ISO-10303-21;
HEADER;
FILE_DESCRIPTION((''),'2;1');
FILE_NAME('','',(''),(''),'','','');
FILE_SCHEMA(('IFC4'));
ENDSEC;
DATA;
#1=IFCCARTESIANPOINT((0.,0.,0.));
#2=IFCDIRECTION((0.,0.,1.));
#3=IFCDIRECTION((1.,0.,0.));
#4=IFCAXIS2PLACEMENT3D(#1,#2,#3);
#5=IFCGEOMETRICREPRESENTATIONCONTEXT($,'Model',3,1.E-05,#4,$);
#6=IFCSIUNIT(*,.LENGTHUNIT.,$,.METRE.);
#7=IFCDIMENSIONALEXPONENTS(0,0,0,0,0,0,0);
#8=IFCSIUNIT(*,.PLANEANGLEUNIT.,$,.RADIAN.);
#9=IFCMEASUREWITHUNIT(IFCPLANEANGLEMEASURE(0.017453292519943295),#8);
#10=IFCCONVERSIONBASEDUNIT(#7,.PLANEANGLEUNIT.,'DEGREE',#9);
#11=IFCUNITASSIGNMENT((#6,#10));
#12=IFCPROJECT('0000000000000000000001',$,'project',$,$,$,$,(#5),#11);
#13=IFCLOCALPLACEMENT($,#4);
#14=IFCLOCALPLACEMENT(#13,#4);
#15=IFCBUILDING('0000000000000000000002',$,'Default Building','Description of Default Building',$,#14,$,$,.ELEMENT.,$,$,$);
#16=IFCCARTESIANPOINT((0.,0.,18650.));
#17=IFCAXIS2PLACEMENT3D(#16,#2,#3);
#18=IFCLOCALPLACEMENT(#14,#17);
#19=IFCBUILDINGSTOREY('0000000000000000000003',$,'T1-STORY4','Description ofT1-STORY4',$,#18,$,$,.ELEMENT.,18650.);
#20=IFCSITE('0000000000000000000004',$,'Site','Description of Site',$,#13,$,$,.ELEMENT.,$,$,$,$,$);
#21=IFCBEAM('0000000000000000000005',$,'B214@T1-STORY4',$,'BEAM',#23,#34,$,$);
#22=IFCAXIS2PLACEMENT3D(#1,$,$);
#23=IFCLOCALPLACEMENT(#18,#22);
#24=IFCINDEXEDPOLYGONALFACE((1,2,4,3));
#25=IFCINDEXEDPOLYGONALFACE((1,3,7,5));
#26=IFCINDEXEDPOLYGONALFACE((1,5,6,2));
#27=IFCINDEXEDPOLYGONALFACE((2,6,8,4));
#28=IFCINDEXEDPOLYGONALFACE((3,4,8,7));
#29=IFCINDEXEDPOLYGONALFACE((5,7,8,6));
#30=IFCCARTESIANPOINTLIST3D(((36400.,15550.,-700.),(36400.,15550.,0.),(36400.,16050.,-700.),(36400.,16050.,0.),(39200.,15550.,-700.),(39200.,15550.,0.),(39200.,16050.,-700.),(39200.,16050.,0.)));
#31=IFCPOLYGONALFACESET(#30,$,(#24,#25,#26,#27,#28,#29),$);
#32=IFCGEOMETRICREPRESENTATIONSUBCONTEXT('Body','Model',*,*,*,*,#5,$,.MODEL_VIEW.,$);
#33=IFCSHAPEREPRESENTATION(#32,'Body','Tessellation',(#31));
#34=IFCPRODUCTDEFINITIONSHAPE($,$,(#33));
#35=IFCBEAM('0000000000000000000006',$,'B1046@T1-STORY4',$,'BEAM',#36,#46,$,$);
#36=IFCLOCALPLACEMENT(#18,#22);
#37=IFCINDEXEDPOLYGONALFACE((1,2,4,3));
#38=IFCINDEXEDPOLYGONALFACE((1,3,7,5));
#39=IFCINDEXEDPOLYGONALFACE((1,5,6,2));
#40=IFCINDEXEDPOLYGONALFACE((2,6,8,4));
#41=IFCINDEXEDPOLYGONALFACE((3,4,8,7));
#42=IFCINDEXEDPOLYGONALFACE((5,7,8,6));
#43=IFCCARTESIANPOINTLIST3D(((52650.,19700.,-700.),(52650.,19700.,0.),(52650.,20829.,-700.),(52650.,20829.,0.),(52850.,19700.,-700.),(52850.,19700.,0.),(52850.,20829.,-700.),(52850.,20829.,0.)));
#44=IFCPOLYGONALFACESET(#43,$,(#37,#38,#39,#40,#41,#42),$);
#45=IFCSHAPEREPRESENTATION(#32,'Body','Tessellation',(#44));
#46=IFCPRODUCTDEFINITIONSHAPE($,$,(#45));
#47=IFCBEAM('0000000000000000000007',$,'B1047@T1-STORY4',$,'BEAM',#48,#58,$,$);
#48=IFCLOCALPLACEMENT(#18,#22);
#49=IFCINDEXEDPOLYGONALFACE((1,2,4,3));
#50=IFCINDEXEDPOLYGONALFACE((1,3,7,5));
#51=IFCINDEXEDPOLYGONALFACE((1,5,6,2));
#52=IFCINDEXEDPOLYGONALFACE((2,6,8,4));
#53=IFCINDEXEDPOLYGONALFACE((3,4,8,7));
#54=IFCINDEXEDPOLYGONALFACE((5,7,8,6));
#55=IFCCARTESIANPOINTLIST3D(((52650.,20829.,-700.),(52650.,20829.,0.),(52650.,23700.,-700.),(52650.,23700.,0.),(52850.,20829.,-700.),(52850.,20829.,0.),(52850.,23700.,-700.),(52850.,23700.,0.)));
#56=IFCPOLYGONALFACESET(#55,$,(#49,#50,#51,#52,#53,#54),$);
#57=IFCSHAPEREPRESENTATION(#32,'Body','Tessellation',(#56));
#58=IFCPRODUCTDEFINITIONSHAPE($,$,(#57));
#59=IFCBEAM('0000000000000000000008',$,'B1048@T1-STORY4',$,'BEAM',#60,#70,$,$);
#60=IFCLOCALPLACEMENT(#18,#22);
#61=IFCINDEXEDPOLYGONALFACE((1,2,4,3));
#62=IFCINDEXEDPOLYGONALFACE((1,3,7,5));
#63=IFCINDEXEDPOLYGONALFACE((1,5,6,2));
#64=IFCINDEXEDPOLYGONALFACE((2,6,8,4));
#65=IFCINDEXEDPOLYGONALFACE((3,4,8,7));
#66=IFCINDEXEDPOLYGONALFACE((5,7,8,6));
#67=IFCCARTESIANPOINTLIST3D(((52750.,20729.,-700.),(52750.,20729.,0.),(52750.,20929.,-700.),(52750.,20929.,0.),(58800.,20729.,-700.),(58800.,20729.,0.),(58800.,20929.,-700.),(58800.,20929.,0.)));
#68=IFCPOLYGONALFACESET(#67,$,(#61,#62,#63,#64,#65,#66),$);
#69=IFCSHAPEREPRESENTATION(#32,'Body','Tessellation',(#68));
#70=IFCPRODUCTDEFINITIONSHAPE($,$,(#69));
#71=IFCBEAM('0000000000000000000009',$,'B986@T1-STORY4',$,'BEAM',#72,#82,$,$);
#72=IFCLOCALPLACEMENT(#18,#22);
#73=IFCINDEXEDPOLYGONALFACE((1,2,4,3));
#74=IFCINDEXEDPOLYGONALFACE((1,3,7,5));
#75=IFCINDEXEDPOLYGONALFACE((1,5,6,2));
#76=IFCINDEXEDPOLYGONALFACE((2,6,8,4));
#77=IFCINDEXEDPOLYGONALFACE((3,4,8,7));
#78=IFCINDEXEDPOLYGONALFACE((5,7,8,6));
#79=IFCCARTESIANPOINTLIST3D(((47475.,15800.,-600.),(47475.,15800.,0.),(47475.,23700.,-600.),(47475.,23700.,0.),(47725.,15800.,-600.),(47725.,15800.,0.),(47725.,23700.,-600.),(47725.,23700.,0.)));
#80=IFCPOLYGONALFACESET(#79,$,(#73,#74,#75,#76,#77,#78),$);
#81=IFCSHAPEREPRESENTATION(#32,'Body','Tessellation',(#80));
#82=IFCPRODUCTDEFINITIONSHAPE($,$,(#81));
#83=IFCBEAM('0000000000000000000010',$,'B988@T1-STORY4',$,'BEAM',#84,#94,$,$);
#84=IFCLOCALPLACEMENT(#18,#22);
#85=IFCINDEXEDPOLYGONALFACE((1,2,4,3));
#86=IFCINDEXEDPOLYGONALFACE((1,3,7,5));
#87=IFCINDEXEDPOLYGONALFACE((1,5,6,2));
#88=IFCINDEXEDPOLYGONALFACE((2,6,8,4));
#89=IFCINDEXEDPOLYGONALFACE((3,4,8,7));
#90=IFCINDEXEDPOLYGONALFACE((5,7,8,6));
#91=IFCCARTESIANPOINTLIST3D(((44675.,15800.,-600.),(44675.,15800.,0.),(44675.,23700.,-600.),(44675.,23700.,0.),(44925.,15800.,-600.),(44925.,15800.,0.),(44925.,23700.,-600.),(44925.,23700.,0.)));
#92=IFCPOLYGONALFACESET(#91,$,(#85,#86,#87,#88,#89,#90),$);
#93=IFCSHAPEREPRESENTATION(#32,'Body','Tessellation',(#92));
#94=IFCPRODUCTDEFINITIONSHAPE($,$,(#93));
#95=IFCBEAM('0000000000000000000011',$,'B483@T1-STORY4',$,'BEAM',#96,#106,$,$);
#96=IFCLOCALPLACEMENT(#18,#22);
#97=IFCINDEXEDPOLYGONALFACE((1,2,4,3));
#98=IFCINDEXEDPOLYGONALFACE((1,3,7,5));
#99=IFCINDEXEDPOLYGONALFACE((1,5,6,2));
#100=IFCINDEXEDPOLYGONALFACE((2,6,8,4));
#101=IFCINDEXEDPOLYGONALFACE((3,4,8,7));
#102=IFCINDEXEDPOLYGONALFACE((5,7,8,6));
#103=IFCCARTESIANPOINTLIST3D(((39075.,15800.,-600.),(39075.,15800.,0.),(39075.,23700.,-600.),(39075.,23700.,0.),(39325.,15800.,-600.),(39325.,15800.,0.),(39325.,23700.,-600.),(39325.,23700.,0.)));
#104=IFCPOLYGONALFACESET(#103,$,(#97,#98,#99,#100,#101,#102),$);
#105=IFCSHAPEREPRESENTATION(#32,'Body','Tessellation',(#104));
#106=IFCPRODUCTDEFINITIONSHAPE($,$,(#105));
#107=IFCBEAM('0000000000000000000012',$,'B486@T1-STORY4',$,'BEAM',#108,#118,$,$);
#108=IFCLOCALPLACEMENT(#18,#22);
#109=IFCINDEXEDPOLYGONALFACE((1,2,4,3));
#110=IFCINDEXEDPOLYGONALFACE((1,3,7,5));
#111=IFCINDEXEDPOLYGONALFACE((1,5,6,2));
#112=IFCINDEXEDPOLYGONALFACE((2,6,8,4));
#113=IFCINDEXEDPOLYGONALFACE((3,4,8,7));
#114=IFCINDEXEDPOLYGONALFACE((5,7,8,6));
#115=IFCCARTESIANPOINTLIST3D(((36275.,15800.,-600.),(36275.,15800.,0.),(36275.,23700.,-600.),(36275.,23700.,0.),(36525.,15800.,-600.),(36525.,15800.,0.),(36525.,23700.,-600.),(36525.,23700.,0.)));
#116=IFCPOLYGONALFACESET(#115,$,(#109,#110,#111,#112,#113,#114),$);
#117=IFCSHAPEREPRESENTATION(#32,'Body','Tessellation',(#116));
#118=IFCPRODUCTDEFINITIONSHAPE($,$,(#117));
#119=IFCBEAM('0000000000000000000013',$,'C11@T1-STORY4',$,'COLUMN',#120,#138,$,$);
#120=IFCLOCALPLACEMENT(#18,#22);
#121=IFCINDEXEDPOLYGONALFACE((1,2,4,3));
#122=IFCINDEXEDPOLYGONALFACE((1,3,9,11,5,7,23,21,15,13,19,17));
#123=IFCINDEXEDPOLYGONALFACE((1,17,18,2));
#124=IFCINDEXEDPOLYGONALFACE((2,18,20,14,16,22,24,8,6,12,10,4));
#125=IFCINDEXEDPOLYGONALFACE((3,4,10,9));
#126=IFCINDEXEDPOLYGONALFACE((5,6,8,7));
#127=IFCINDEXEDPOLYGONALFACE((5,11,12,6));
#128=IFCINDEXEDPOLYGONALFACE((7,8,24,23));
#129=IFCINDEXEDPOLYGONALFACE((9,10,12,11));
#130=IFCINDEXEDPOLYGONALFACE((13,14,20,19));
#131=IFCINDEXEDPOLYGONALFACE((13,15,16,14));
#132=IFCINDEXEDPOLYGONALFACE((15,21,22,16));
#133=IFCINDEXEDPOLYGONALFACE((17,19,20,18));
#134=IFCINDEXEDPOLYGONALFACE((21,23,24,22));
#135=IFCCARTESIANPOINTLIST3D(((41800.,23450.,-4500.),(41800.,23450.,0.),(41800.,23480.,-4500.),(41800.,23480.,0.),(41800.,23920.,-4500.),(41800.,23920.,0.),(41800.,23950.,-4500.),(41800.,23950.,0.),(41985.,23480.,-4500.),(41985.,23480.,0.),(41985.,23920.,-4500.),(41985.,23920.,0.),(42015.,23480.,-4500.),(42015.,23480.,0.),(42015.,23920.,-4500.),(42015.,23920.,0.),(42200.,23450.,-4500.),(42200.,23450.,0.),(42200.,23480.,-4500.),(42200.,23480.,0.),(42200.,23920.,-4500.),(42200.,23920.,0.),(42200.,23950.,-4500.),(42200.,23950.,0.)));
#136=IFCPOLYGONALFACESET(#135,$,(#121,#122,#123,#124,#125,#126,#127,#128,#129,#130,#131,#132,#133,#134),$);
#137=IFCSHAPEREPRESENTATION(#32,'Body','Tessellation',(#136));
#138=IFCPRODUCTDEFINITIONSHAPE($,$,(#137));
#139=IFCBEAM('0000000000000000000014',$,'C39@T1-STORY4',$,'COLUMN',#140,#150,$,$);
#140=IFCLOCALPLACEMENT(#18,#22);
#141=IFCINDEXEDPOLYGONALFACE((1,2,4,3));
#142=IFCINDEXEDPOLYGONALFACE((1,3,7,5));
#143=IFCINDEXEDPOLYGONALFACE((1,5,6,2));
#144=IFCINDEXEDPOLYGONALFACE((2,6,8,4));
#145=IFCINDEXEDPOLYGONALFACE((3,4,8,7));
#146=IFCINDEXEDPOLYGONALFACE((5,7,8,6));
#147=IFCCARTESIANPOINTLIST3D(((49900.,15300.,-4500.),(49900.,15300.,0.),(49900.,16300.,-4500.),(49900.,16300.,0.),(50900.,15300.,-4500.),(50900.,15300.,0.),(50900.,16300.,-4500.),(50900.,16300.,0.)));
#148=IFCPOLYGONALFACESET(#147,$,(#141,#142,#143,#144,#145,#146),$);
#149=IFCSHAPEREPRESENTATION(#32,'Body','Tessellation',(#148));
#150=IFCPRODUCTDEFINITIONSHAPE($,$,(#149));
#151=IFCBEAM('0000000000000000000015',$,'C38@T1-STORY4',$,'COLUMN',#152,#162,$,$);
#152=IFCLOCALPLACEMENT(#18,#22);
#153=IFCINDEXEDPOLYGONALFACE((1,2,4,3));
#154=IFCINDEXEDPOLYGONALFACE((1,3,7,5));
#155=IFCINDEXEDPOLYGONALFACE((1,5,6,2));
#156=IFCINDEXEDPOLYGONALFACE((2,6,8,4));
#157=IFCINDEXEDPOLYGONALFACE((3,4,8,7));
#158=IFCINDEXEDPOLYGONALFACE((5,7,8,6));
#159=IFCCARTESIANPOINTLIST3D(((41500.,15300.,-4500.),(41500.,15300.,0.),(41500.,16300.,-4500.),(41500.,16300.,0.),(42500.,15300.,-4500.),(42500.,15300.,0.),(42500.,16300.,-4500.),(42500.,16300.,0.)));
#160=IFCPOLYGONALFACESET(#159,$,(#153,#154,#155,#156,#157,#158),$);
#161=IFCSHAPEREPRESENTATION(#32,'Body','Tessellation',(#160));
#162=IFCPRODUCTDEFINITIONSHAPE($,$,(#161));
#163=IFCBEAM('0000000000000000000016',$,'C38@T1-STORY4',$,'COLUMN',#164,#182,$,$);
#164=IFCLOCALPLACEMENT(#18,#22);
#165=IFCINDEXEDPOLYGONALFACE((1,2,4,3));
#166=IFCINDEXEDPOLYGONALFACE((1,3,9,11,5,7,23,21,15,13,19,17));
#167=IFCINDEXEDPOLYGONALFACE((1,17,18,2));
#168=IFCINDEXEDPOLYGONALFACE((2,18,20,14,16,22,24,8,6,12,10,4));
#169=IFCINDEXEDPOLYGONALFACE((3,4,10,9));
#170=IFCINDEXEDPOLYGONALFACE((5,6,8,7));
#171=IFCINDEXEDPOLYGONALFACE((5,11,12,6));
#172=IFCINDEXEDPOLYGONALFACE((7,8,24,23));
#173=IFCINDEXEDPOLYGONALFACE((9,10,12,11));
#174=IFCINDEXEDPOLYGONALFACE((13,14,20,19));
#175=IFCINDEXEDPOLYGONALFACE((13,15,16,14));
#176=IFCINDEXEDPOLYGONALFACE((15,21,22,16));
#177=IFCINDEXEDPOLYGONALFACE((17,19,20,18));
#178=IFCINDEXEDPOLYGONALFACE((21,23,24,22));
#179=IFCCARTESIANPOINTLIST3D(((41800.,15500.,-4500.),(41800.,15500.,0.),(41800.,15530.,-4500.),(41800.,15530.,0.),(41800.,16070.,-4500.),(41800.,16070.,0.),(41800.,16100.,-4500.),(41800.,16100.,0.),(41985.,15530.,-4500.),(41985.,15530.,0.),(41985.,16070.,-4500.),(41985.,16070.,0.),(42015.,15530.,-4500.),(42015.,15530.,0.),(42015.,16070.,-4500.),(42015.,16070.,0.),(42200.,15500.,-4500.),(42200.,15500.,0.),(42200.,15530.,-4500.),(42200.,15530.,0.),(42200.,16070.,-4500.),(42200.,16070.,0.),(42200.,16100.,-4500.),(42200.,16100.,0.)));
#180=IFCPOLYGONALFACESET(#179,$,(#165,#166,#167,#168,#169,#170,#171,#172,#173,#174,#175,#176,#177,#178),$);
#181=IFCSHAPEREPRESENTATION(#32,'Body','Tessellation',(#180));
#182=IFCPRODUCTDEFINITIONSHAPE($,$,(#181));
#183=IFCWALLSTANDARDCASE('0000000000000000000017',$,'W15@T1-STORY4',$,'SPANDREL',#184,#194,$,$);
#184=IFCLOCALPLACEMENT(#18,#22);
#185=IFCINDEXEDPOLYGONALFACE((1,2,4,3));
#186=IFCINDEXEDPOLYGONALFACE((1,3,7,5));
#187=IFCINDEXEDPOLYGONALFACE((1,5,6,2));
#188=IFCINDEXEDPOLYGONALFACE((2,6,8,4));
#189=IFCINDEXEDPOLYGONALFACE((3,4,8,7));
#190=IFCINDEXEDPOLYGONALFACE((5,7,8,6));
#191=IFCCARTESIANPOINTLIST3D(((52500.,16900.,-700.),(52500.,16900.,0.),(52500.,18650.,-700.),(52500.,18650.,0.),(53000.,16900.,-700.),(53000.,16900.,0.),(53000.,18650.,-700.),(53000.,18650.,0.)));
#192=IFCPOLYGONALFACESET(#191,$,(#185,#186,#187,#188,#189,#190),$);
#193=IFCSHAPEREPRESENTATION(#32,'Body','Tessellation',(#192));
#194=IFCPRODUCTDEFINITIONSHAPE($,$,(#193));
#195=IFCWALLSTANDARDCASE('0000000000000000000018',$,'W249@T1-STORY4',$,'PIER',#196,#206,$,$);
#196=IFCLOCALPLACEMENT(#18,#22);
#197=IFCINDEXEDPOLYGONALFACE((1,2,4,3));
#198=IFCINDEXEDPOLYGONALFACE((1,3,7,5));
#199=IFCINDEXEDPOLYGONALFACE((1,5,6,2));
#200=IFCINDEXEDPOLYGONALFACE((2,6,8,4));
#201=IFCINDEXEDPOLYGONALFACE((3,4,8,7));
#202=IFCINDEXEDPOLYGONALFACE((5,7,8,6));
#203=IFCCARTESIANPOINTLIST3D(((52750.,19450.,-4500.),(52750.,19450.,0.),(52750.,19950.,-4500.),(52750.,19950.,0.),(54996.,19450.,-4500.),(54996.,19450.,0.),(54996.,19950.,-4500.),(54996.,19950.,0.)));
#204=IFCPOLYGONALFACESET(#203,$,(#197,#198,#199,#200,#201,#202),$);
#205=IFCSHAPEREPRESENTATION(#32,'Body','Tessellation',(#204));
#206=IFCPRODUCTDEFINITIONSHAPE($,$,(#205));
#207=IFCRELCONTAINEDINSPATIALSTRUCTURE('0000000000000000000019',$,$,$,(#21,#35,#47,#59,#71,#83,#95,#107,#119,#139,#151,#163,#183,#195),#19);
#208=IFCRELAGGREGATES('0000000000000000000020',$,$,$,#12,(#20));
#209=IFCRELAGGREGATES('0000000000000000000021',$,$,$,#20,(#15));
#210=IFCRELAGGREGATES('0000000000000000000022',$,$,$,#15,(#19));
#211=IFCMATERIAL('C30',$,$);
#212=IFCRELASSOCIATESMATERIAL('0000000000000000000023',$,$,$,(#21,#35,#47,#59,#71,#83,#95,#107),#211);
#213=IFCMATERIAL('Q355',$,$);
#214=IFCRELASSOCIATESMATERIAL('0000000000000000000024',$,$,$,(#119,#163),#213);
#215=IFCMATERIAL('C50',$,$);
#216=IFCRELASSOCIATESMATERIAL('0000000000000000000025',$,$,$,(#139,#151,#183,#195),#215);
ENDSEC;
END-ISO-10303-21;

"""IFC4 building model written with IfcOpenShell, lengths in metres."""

from ifc_helpers import new_model, entity, si_unit, converted_unit, frame, origin_with_axes, place, context, subcontext, project, spatial, indexed_curve, rectangle, i_section, outline, extrude, material, element, save


model = new_model("IFC4")

# Units and contexts
model_context = context("Model", 3, precision=1e-05, world=origin_with_axes())
body_context = subcontext(model_context, "Body", "Model", "MODEL_VIEW")
ifc_project = project(units=[si_unit("LENGTHUNIT", "METRE"), converted_unit("PLANEANGLEUNIT", "DEGREE", entity("IfcPlaneAngleMeasure", 0.017453292519943295), si_unit("PLANEANGLEUNIT", "RADIAN"), dimensions=[0, 0, 0, 0, 0, 0, 0])], contexts=[model_context])

# Site, building, storey
site_placement = place(None, origin_with_axes())
site = spatial("IfcSite", under=ifc_project, at=site_placement, Name="Site", Description="Description of Site", CompositionType="ELEMENT")
building_placement = place(site_placement, origin_with_axes())
building = spatial("IfcBuilding", under=site, at=building_placement, Name="Default Building", Description="Description of Default Building", CompositionType="ELEMENT")
storey_placement = place(building_placement, frame((0.0, 0.0, 18650.0), z_axis=(0.0, 0.0, 1.0), x_axis=(1.0, 0.0, 0.0)))
storey = spatial("IfcBuildingStorey", under=building, at=storey_placement, Name="T1-STORY4", Description="Description ofT1-STORY4", CompositionType="ELEMENT", Elevation=18650.0)

# Beams
ifc_material_1 = material(Name="C30")
for number, where, z_axis, x_axis, name in (
    (1, (36400.0, 15800.0, -350.0), (1.0, 0.0, 0.0), (0.0, 1.0, 0.0), "B214@T1-STORY4"),
):
    element("IfcBeam", number, at=place(storey_placement, frame(where, z_axis=z_axis, x_axis=x_axis)), inside=storey, material=ifc_material_1, Name=name, ObjectType="BEAM", context=body_context, shape_type="SweptSolid", body=[
        extrude(rectangle(XDim=500.0, YDim=700.0), origin_with_axes(), (0.0, 0.0, 1.0), 2800.0),
    ])
beam_1_placement = place(storey_placement, frame((52750.0, 19700.0, -350.0), z_axis=(0.0, 1.0, 0.0), x_axis=(-1.0, 0.0, 0.0)))
element("IfcBeam", 2, at=beam_1_placement, inside=storey, material=ifc_material_1, Name="B1046@T1-STORY4", ObjectType="BEAM", context=body_context, shape_type="SweptSolid", body=[
    extrude(rectangle(XDim=200.0, YDim=700.0), origin_with_axes(), (0.0, 0.0, 1.0), 1129.0),
])
beam_2_placement = place(storey_placement, frame((52750.0, 20829.0, -350.0), z_axis=(0.0, 1.0, 0.0), x_axis=(-1.0, 0.0, 0.0)))
element("IfcBeam", 3, at=beam_2_placement, inside=storey, material=ifc_material_1, Name="B1047@T1-STORY4", ObjectType="BEAM", context=body_context, shape_type="SweptSolid", body=[
    extrude(rectangle(XDim=200.0, YDim=700.0), origin_with_axes(), (0.0, 0.0, 1.0), 2871.0),
])
beam_3_placement = place(storey_placement, frame((52750.0, 20829.0, -350.0), z_axis=(1.0, 0.0, 0.0), x_axis=(0.0, 1.0, 0.0)))
element("IfcBeam", 4, at=beam_3_placement, inside=storey, material=ifc_material_1, Name="B1048@T1-STORY4", ObjectType="BEAM", context=body_context, shape_type="SweptSolid", body=[
    extrude(rectangle(XDim=200.0, YDim=700.0), origin_with_axes(), (0.0, 0.0, 1.0), 6050.0),
])
for number, where, z_axis, x_axis, name in (
    (5, (47600.0, 15800.0, -300.0), (0.0, 1.0, 0.0), (-1.0, 0.0, 0.0), "B986@T1-STORY4"),
    (6, (44800.0, 15800.0, -300.0), (0.0, 1.0, 0.0), (-1.0, 0.0, 0.0), "B988@T1-STORY4"),
    (7, (39200.0, 15800.0, -300.0), (0.0, 1.0, 0.0), (-1.0, 0.0, 0.0), "B483@T1-STORY4"),
    (8, (36400.0, 15800.0, -300.0), (0.0, 1.0, 0.0), (-1.0, 0.0, 0.0), "B486@T1-STORY4"),
):
    element("IfcBeam", number, at=place(storey_placement, frame(where, z_axis=z_axis, x_axis=x_axis)), inside=storey, material=ifc_material_1, Name=name, ObjectType="BEAM", context=body_context, shape_type="SweptSolid", body=[
        extrude(rectangle(XDim=250.0, YDim=600.0), origin_with_axes(), (0.0, 0.0, 1.0), 7900.0),
    ])
ifc_material_2 = material(Name="C50")
ifc_material_3 = material(Name="Q355")
beam_4_placement = place(storey_placement, frame((42000.0, 23700.0, -4500.0), z_axis=(0.0, 0.0, 1.0), x_axis=(-1.0, 0.0, 0.0)))
element("IfcBeam", 9, at=beam_4_placement, inside=storey, material=ifc_material_3, Name="C11@T1-STORY4", ObjectType="COLUMN", context=body_context, shape_type="SweptSolid", body=[
    extrude(i_section(OverallWidth=400.0, OverallDepth=500.0, WebThickness=30.0, FlangeThickness=30.0, FilletRadius=0.0), origin_with_axes(), (0.0, 0.0, 1.0), 4500.0),
])
for number, where, z_axis, x_axis, name in (
    (10, (50400.0, 15800.0, -4500.0), (0.0, 0.0, 1.0), (-1.0, 0.0, 0.0), "C39@T1-STORY4"),
    (11, (42000.0, 15800.0, -4500.0), (0.0, 0.0, 1.0), (-1.0, 0.0, 0.0), "C38@T1-STORY4"),
):
    element("IfcBeam", number, at=place(storey_placement, frame(where, z_axis=z_axis, x_axis=x_axis)), inside=storey, material=ifc_material_2, Name=name, ObjectType="COLUMN", context=body_context, shape_type="SweptSolid", body=[
        extrude(rectangle(XDim=1000.0, YDim=1000.0), origin_with_axes(), (0.0, 0.0, 1.0), 4500.0),
    ])
beam_5_placement = place(storey_placement, frame((42000.0, 15800.0, -4500.0), z_axis=(0.0, 0.0, 1.0), x_axis=(-1.0, 0.0, 0.0)))
element("IfcBeam", 12, at=beam_5_placement, inside=storey, material=ifc_material_3, Name="C38@T1-STORY4", ObjectType="COLUMN", context=body_context, shape_type="SweptSolid", body=[
    extrude(i_section(OverallWidth=400.0, OverallDepth=600.0, WebThickness=30.0, FlangeThickness=30.0, FilletRadius=0.0), origin_with_axes(), (0.0, 0.0, 1.0), 4500.0),
])

# Walls
wall_1_placement = place(storey_placement, frame((52750.0, 16900.0, -700.0), z_axis=(0.0, 0.0, 1.0), x_axis=(0.0, 1.0, 0.0)))
element("IfcWallStandardCase", 13, at=wall_1_placement, inside=storey, material=ifc_material_2, Name="W15@T1-STORY4", ObjectType="SPANDREL", context=body_context, shape_type="SweptSolid", body=[
    extrude(outline(indexed_curve([(0.0, -250.0), (0.0, 250.0), (1750.0, 250.0), (1750.0, -250.0), (0.0, -250.0)], self_intersect=False)), origin_with_axes(), (0.0, 0.0, 1.0), 700.0),
])
wall_2_placement = place(storey_placement, frame((52750.0, 19700.0, -4500.0), z_axis=(0.0, 0.0, 1.0), x_axis=(1.0, 0.0, 0.0)))
element("IfcWallStandardCase", 14, at=wall_2_placement, inside=storey, material=ifc_material_2, Name="W249@T1-STORY4", ObjectType="PIER", context=body_context, shape_type="SweptSolid", body=[
    extrude(outline(indexed_curve([(0.0, -250.0), (0.0, 250.0), (2246.0, 250.0), (2246.0, -250.0), (0.0, -250.0)], self_intersect=False)), origin_with_axes(), (0.0, 0.0, 1.0), 4500.0),
])

save(model, "model.ifc")
